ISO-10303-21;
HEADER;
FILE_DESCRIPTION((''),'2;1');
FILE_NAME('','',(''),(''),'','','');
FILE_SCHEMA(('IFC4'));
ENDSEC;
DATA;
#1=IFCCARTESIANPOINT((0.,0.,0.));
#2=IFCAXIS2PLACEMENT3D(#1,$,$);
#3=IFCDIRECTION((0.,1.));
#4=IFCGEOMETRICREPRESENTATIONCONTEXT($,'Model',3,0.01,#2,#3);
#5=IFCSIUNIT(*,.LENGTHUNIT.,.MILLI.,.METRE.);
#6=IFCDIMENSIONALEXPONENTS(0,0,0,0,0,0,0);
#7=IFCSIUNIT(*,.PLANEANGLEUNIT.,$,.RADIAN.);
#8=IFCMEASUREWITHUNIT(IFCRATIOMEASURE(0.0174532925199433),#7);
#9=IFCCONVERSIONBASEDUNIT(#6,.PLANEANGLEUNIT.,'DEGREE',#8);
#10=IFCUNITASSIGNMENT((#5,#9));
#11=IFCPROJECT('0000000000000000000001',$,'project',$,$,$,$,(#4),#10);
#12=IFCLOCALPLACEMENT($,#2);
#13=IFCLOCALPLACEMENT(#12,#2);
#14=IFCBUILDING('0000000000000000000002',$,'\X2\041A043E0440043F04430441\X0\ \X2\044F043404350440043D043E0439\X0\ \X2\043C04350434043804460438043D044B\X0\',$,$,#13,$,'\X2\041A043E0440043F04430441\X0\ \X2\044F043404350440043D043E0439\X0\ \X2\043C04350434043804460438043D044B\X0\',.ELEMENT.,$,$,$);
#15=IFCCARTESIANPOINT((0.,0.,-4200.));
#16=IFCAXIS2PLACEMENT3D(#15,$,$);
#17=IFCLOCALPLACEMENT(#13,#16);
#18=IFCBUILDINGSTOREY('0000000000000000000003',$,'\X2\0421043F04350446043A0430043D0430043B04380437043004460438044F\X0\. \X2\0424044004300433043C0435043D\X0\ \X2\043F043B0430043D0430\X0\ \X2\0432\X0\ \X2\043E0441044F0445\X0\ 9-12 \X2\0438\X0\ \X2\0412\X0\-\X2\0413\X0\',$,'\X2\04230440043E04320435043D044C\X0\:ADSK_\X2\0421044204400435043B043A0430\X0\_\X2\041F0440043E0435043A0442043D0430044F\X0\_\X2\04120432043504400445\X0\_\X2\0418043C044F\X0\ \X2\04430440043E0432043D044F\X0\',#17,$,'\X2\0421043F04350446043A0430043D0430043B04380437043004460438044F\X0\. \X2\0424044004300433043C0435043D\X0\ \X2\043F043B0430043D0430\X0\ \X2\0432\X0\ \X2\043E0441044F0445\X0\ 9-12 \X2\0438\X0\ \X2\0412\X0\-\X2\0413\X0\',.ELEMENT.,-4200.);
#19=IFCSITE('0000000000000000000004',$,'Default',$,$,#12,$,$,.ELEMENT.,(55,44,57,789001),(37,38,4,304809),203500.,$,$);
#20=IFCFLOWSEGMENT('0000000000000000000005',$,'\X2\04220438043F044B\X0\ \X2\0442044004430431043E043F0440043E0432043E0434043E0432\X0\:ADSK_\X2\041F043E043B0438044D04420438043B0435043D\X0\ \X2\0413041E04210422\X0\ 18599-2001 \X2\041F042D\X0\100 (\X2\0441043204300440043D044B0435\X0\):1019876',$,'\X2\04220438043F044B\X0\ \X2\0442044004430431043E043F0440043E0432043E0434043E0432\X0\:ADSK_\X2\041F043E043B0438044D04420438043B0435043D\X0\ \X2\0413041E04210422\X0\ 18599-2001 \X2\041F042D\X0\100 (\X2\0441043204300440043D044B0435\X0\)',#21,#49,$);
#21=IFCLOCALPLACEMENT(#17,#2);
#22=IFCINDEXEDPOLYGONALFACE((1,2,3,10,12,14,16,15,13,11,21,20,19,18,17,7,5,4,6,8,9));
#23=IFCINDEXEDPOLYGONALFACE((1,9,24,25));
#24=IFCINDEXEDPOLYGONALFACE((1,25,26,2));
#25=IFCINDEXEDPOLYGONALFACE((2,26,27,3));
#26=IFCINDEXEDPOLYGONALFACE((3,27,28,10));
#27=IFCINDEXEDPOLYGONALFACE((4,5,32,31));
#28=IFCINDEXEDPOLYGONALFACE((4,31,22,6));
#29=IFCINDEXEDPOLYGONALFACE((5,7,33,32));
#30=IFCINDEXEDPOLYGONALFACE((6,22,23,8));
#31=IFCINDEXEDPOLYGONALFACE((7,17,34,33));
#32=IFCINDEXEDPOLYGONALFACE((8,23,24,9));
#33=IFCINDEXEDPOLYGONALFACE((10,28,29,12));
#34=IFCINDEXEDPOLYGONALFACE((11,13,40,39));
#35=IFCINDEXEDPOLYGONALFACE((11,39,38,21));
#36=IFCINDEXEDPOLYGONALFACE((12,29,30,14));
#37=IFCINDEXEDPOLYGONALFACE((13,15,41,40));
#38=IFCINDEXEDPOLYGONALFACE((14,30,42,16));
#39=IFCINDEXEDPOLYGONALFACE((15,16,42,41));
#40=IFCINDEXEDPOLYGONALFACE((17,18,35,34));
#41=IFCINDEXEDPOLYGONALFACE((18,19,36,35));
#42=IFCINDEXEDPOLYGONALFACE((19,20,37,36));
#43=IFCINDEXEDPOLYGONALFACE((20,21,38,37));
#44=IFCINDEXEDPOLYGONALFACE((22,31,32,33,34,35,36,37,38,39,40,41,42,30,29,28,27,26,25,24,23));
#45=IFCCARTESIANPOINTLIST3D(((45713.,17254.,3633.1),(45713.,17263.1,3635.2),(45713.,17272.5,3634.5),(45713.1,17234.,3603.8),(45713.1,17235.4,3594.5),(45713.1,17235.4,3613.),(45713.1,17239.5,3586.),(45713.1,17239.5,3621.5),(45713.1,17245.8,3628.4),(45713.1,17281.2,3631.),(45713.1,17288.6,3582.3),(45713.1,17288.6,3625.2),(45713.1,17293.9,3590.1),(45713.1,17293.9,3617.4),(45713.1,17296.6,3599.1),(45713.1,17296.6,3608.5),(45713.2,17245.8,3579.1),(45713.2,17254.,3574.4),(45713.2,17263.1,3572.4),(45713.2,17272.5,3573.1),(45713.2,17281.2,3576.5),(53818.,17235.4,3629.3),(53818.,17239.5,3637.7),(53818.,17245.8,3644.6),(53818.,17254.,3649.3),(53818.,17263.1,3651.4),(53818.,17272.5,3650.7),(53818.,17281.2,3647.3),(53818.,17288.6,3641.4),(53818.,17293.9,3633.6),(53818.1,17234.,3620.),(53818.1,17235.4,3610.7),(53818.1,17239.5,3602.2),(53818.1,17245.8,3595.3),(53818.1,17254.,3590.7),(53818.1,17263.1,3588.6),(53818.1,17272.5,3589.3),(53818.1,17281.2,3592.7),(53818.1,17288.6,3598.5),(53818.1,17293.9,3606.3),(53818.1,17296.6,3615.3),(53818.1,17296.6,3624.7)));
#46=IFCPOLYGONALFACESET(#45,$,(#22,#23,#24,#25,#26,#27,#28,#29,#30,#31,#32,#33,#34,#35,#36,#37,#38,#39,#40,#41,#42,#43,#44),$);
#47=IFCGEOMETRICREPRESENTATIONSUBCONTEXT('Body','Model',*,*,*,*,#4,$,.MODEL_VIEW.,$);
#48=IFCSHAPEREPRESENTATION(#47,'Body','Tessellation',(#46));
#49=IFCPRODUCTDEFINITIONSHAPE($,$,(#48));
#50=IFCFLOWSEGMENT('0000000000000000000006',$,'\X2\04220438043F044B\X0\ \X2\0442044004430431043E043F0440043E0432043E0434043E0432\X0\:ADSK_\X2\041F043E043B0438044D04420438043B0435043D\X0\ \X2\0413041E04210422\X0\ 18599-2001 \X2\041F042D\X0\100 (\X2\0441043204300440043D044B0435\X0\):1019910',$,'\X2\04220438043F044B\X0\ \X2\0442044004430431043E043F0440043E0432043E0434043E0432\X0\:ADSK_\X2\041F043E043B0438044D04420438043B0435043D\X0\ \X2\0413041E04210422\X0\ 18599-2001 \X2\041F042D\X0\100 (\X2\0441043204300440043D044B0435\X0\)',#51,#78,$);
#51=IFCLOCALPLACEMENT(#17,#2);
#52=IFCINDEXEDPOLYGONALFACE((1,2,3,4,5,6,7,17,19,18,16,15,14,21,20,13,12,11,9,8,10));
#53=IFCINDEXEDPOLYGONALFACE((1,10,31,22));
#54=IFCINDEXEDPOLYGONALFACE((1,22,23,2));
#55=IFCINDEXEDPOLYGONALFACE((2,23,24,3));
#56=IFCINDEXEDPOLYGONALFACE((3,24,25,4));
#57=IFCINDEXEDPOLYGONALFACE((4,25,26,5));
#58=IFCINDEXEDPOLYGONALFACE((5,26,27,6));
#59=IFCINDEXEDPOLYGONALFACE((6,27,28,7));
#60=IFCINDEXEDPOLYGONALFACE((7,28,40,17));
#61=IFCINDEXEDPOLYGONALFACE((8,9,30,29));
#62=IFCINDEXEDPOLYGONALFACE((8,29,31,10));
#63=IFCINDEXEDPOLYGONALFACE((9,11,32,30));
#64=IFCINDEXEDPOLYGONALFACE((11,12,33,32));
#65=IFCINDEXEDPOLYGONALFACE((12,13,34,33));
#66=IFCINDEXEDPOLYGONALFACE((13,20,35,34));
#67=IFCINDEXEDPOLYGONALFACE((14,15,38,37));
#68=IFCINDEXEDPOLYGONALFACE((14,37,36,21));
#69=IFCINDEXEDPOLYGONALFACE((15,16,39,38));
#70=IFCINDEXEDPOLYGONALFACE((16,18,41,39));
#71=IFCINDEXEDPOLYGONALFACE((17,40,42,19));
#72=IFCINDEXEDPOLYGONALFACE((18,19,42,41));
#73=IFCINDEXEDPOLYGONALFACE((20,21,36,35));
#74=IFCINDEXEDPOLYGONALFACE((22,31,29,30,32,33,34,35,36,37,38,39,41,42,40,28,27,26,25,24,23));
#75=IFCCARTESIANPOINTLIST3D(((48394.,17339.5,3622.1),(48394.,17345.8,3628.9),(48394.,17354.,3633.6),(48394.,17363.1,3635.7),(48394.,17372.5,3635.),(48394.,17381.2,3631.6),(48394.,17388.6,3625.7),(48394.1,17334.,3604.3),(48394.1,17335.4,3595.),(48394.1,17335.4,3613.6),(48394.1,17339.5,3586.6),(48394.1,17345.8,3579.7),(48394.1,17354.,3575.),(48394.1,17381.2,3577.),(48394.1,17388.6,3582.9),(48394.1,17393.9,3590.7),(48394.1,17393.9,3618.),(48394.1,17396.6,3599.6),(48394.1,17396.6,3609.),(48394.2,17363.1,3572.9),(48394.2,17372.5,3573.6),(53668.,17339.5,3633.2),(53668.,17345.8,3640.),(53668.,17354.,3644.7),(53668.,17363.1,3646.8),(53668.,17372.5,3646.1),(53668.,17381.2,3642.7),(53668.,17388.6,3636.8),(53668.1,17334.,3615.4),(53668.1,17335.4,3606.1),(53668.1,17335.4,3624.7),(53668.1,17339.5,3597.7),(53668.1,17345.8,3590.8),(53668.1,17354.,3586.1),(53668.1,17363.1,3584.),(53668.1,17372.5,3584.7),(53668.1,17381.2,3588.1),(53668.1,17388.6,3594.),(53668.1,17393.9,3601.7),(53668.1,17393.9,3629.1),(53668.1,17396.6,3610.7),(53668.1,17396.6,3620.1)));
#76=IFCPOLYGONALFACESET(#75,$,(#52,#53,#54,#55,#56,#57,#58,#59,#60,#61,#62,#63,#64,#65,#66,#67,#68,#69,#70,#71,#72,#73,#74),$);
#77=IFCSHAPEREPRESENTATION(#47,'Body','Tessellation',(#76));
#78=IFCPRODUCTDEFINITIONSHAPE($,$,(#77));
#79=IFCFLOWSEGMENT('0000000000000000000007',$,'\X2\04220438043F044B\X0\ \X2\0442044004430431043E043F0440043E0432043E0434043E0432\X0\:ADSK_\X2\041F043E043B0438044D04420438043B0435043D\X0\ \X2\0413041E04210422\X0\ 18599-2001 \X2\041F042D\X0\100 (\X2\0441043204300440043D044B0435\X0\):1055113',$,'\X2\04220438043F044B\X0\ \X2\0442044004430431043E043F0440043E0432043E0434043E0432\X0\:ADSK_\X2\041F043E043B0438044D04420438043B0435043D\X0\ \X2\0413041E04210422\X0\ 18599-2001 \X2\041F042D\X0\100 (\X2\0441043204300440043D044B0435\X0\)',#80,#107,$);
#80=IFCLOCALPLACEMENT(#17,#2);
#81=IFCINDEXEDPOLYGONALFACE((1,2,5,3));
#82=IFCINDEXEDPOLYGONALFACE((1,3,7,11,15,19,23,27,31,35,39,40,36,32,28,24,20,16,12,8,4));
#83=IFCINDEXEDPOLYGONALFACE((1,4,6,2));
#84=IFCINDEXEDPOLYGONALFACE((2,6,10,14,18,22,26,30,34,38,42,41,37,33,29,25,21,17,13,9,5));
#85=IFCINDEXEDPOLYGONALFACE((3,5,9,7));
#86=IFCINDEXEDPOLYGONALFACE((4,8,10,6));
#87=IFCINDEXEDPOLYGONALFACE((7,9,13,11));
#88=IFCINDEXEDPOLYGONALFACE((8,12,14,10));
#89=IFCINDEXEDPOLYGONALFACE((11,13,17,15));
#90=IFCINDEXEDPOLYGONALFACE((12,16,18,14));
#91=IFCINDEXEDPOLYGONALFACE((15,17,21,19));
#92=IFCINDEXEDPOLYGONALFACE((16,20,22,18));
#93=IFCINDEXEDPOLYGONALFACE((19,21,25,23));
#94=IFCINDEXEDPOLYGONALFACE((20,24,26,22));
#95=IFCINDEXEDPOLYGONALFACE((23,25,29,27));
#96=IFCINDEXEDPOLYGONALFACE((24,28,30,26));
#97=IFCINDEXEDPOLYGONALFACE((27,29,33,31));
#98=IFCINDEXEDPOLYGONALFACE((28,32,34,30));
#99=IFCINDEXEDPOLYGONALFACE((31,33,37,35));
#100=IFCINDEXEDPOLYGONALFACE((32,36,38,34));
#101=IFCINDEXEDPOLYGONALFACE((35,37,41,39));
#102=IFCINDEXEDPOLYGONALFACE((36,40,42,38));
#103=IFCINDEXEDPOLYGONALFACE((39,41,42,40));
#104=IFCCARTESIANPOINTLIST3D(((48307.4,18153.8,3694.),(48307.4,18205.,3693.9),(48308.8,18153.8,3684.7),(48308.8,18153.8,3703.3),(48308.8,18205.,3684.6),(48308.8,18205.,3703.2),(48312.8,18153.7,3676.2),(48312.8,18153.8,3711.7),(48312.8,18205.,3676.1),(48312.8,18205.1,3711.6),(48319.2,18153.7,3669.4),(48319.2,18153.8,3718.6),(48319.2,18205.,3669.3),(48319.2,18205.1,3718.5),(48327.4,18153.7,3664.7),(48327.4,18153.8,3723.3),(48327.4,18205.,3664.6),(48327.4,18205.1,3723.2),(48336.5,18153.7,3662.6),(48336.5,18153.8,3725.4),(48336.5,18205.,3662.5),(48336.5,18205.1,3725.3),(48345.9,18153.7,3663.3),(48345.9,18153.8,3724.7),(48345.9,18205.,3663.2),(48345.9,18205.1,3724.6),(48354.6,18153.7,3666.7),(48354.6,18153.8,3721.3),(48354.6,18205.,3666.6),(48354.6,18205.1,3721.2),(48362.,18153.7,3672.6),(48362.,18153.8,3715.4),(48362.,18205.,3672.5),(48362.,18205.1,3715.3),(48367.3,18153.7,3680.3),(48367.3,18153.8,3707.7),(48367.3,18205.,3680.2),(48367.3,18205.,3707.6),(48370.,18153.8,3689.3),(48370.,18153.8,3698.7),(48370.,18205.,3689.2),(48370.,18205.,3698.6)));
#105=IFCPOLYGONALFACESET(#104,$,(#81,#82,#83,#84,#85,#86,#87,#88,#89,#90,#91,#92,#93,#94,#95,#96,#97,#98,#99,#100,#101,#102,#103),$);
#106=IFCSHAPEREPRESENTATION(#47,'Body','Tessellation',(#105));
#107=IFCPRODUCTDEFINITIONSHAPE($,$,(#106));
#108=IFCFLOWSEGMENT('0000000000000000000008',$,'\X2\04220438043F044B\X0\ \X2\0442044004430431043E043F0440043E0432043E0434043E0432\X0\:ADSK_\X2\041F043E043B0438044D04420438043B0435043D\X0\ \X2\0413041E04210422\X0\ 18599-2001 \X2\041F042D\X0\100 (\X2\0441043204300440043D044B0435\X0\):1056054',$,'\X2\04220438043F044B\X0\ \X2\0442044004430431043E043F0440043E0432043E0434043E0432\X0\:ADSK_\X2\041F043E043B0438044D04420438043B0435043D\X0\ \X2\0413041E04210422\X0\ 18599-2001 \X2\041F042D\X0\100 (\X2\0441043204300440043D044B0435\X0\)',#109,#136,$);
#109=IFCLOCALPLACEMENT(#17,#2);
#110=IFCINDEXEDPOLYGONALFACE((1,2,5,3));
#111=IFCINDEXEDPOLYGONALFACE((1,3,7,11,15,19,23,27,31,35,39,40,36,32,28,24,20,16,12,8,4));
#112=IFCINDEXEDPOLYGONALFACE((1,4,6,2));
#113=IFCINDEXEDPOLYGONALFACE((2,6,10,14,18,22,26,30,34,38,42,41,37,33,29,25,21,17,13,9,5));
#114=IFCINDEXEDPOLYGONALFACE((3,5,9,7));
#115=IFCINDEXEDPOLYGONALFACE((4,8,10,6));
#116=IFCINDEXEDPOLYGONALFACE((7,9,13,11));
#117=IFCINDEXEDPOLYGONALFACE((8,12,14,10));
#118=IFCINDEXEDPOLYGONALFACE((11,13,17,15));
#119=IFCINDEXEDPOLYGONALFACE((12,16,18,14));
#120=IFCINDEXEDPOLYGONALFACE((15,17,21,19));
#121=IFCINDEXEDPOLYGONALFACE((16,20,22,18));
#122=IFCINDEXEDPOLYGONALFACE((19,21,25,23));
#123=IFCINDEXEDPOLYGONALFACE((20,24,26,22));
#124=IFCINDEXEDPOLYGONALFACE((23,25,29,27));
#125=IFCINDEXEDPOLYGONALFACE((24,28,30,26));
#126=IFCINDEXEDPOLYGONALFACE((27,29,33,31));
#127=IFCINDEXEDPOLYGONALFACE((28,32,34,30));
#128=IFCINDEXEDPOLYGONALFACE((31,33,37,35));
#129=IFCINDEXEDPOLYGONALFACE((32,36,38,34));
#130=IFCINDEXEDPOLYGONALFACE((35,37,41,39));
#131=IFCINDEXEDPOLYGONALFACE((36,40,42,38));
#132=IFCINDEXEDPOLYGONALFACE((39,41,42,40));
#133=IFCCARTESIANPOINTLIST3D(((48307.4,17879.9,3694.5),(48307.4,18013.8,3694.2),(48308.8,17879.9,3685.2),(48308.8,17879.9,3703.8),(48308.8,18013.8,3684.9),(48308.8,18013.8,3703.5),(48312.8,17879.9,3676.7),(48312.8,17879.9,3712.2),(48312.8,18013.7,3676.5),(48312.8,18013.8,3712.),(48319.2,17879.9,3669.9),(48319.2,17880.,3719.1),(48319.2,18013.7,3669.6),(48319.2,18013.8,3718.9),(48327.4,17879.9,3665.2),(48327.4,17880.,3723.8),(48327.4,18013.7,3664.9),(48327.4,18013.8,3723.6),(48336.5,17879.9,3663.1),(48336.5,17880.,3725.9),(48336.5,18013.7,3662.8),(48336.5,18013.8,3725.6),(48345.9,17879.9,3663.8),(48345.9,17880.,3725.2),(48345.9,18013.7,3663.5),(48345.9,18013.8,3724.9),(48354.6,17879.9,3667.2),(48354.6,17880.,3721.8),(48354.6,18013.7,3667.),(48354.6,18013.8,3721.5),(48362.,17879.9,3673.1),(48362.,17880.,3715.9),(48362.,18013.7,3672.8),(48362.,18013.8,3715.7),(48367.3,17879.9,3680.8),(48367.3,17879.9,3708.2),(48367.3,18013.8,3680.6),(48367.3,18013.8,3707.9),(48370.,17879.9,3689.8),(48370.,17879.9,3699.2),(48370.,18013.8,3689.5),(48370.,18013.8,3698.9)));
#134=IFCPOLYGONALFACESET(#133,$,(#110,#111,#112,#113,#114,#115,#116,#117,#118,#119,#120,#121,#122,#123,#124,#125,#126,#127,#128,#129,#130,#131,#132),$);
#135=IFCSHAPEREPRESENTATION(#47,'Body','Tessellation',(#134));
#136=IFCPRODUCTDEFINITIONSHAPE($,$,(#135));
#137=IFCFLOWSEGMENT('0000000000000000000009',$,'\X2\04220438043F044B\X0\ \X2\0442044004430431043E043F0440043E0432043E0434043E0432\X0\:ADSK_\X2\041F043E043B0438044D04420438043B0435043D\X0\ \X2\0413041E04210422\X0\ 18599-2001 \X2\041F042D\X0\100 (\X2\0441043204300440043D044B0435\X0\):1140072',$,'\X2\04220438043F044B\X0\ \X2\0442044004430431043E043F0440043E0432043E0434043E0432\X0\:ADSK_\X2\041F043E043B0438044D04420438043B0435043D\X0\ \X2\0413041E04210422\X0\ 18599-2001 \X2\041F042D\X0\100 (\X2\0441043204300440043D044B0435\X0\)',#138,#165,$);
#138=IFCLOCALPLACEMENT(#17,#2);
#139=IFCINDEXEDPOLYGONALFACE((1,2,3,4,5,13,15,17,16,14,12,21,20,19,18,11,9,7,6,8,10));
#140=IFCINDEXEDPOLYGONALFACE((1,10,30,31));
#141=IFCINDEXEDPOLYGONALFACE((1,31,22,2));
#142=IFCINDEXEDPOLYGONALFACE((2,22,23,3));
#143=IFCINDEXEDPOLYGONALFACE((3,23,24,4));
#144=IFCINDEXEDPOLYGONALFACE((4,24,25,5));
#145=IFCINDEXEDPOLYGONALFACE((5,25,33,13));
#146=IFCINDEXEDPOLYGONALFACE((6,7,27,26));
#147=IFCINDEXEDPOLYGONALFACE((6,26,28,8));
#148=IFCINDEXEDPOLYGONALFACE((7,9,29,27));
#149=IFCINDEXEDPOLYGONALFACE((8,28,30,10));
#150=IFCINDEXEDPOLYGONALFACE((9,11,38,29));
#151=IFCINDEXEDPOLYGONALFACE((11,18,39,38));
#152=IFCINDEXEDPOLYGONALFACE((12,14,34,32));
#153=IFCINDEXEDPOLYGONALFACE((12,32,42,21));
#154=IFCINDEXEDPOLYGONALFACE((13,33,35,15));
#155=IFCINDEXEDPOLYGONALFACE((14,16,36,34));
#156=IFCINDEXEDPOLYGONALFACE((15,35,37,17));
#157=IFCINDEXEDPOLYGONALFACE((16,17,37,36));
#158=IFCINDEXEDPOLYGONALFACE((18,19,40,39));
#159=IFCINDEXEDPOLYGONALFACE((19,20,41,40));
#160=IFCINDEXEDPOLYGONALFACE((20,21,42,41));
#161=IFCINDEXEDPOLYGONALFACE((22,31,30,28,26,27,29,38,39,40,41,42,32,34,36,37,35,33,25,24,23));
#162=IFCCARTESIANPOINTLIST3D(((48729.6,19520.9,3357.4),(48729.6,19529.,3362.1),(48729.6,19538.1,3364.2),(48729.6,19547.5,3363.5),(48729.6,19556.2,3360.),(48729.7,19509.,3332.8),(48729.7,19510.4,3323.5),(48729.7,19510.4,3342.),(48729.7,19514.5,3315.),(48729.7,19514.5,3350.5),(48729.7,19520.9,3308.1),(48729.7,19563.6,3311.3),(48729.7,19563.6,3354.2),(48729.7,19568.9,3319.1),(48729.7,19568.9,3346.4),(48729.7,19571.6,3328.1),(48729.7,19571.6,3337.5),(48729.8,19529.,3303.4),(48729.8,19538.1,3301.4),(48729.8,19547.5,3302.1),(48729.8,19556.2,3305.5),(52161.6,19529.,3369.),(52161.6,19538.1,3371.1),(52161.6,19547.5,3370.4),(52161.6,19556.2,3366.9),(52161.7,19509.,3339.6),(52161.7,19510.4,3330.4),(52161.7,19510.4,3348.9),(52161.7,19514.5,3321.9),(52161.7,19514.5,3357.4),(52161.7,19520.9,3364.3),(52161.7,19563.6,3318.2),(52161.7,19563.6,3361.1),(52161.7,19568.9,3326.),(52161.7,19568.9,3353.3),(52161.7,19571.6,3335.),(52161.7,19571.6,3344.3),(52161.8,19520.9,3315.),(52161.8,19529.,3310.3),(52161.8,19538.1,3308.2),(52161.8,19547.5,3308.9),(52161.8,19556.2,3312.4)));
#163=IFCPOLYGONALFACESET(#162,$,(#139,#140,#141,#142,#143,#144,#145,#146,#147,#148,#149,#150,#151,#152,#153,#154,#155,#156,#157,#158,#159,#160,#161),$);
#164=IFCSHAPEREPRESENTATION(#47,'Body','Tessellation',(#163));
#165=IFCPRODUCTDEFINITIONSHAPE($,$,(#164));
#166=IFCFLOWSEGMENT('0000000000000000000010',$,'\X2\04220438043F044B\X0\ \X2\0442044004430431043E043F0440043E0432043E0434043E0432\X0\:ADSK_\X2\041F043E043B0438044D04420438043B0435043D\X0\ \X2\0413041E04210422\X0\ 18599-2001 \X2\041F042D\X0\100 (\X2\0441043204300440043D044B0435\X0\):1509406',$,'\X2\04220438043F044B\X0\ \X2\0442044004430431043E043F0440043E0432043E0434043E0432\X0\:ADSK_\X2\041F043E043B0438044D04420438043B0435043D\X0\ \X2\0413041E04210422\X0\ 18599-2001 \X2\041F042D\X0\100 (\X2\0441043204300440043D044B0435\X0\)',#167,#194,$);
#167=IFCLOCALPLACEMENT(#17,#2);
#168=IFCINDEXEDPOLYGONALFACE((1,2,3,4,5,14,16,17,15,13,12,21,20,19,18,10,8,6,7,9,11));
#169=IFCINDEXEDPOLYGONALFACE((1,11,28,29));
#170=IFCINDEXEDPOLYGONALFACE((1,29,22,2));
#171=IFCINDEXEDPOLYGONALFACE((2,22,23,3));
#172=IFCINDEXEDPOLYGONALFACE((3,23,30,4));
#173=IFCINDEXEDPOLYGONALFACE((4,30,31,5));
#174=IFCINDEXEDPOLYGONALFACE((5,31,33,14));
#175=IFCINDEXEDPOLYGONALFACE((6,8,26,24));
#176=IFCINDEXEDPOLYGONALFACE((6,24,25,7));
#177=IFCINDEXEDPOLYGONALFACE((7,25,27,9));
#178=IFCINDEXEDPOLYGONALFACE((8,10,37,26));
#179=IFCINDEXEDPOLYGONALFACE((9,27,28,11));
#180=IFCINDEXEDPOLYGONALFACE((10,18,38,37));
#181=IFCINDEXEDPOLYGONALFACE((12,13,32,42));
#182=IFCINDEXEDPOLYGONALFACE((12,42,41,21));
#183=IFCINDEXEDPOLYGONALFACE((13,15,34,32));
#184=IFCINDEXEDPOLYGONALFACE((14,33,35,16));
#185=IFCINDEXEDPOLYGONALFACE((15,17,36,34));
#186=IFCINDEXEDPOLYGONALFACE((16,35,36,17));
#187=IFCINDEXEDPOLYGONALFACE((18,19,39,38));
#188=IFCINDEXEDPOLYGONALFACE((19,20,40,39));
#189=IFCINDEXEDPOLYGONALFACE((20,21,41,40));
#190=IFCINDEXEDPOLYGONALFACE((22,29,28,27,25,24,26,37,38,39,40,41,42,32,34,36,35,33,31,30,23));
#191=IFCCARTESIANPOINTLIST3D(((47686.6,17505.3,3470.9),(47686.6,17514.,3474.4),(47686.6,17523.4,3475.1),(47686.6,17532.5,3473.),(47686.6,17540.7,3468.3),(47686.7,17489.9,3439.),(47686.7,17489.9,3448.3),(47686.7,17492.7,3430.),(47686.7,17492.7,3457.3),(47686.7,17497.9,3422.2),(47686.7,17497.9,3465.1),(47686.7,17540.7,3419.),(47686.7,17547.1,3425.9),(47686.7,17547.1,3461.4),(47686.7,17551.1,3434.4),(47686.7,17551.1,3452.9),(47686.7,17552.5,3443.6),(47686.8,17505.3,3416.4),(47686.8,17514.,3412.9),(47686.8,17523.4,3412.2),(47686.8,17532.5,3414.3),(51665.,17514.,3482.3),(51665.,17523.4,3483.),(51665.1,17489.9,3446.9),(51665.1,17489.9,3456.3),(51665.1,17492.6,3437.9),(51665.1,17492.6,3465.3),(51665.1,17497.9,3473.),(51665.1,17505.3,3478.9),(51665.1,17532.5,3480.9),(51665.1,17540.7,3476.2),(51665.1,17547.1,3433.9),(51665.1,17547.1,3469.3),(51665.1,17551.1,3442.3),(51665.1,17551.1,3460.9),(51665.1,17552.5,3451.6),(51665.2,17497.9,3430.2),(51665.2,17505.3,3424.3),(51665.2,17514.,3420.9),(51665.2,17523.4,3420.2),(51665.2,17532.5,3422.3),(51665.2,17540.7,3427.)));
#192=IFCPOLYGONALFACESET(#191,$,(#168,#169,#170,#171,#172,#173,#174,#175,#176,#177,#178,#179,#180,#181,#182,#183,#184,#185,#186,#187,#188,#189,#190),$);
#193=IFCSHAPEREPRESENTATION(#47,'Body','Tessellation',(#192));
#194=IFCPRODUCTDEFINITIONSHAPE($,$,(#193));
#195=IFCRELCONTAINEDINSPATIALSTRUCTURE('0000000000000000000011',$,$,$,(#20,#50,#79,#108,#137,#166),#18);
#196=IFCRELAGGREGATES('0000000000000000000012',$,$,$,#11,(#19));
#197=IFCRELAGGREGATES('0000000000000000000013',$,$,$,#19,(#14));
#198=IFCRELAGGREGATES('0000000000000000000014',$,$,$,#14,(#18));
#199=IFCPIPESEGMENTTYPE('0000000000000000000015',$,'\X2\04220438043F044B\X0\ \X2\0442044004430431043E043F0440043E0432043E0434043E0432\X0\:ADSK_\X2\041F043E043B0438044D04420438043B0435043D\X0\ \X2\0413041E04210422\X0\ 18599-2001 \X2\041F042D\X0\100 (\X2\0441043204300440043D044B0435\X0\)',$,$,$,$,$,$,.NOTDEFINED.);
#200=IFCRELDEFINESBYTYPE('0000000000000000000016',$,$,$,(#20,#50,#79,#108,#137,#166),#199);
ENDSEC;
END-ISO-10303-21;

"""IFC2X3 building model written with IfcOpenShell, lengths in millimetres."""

from ifc_helpers import new_model, entity, si_unit, converted_unit, direction, frame, frame_2d, origin, origin_2d_with_axis, place, context, subcontext, project, spatial, circle, extrude, type_object, element, save


model = new_model("IFC2X3")

# Units and contexts
model_context = context("Model", 3, precision=0.01, world=origin(), true_north=direction((0.0, 1.0)))
body_context = subcontext(model_context, "Body", "Model", "MODEL_VIEW")
ifc_project = project(units=[si_unit("LENGTHUNIT", "METRE", prefix="MILLI"), converted_unit("PLANEANGLEUNIT", "DEGREE", entity("IfcRatioMeasure", 0.0174532925199433), si_unit("PLANEANGLEUNIT", "RADIAN"), dimensions=[0, 0, 0, 0, 0, 0, 0])], contexts=[model_context])

# Site, building, storey
site_placement = place(None, frame((0.0, 0.0, 0.0)))
site = spatial("IfcSite", under=ifc_project, at=site_placement, Name="Default", CompositionType="ELEMENT", RefLatitude=(55, 44, 57, 789001), RefLongitude=(37, 38, 4, 304809), RefElevation=203500.0)
building_placement = place(site_placement, origin())
building = spatial("IfcBuilding", under=site, at=building_placement, Name="Корпус ядерной медицины", LongName="Корпус ядерной медицины", CompositionType="ELEMENT")
storey_placement = place(building_placement, frame((0.0, 0.0, -4200.0)))
storey = spatial("IfcBuildingStorey", under=building, at=storey_placement, Name="Спецканализация. Фрагмен плана в осях 9-12 и В-Г", ObjectType="Уровень:ADSK_Стрелка_Проектная_Вверх_Имя уровня", LongName="Спецканализация. Фрагмен плана в осях 9-12 и В-Г", CompositionType="ELEMENT", Elevation=-4200.0)

# Flow segments
pipe_segment_type = type_object("IfcPipeSegmentType", Name="Типы трубопроводов:ADSK_Полиэтилен ГОСТ 18599-2001 ПЭ100 (сварные)", PredefinedType="NOTDEFINED")
flow_segment_1_placement = place(storey_placement, frame((45713.0, 17232.4, 3570.7)))
element("IfcFlowSegment", 1, at=flow_segment_1_placement, inside=storey, type_object=pipe_segment_type, Name="Типы трубопроводов:ADSK_Полиэтилен ГОСТ 18599-2001 ПЭ100 (сварные):1019876", ObjectType="Типы трубопроводов:ADSK_Полиэтилен ГОСТ 18599-2001 ПЭ100 (сварные)", context=body_context, shape_type="SweptSolid", body=[
    extrude(circle(Radius=31.5, at=frame_2d((0.0, 0.0), x_axis=(1.0, 0.0))), frame((0.1, 33.1, 33.1), z_axis=(0.999998, 0.0, 0.002), x_axis=(0.0, -1.0, 0.0)), (0.0, 0.0, 1.0), 8105.0),
])
flow_segment_2_placement = place(storey_placement, frame((48394.0, 17332.4, 3571.2)))
element("IfcFlowSegment", 2, at=flow_segment_2_placement, inside=storey, type_object=pipe_segment_type, Name="Типы трубопроводов:ADSK_Полиэтилен ГОСТ 18599-2001 ПЭ100 (сварные):1019910", ObjectType="Типы трубопроводов:ADSK_Полиэтилен ГОСТ 18599-2001 ПЭ100 (сварные)", context=body_context, shape_type="SweptSolid", body=[
    extrude(circle(Radius=31.5, at=frame_2d((0.0, 0.0), x_axis=(1.0, 0.0))), frame((0.1, 33.1, 33.1), z_axis=(0.999998, 0.0, 0.002102), x_axis=(0.0, -1.0, 0.0)), (0.0, 0.0, 1.0), 5274.0),
])
flow_segment_3_placement = place(storey_placement, frame((48305.8, 18153.7, 3660.8)))
element("IfcFlowSegment", 3, at=flow_segment_3_placement, inside=storey, type_object=pipe_segment_type, Name="Типы трубопроводов:ADSK_Полиэтилен ГОСТ 18599-2001 ПЭ100 (сварные):1055113", ObjectType="Типы трубопроводов:ADSK_Полиэтилен ГОСТ 18599-2001 ПЭ100 (сварные)", context=body_context, shape_type="SweptSolid", body=[
    extrude(circle(Radius=31.5, at=origin_2d_with_axis()), frame((33.1, 0.1, 33.2), z_axis=(0.0, 0.999998, -0.002), x_axis=(-1.0, 0.0, 0.0)), (0.0, 0.0, 1.0), 51.2),
])
flow_segment_4_placement = place(storey_placement, frame((48305.8, 17879.9, 3661.1)))
element("IfcFlowSegment", 4, at=flow_segment_4_placement, inside=storey, type_object=pipe_segment_type, Name="Типы трубопроводов:ADSK_Полиэтилен ГОСТ 18599-2001 ПЭ100 (сварные):1056054", ObjectType="Типы трубопроводов:ADSK_Полиэтилен ГОСТ 18599-2001 ПЭ100 (сварные)", context=body_context, shape_type="SweptSolid", body=[
    extrude(circle(Radius=31.5, at=origin_2d_with_axis()), frame((33.1, 133.9, 33.1), z_axis=(-0.000004, -0.999998, 0.001928), x_axis=(-1.0, 0.000004, 0.0)), (0.0, 0.0, 1.0), 133.9),
])
flow_segment_5_placement = place(storey_placement, frame((48729.6, 19507.4, 3299.7)))
element("IfcFlowSegment", 5, at=flow_segment_5_placement, inside=storey, type_object=pipe_segment_type, Name="Типы трубопроводов:ADSK_Полиэтилен ГОСТ 18599-2001 ПЭ100 (сварные):1140072", ObjectType="Типы трубопроводов:ADSK_Полиэтилен ГОСТ 18599-2001 ПЭ100 (сварные)", context=body_context, shape_type="SweptSolid", body=[
    extrude(circle(Radius=31.5, at=origin_2d_with_axis()), frame((0.1, 33.1, 33.1), z_axis=(0.999998, 0.0, 0.002006), x_axis=(0.0, -1.0, 0.0)), (0.0, 0.0, 1.0), 3432.0),
])
flow_segment_6_placement = place(storey_placement, frame((47686.6, 17487.9, 3410.6)))
element("IfcFlowSegment", 6, at=flow_segment_6_placement, inside=storey, type_object=pipe_segment_type, Name="Типы трубопроводов:ADSK_Полиэтилен ГОСТ 18599-2001 ПЭ100 (сварные):1509406", ObjectType="Типы трубопроводов:ADSK_Полиэтилен ГОСТ 18599-2001 ПЭ100 (сварные)", context=body_context, shape_type="SweptSolid", body=[
    extrude(circle(Radius=31.5, at=origin_2d_with_axis()), frame((0.1, 33.1, 33.1), z_axis=(0.999998, -0.000004, 0.001999), x_axis=(0.000004, 1.0, 0.0)), (0.0, 0.0, 1.0), 3978.4),
])

save(model, "model.ifc")
